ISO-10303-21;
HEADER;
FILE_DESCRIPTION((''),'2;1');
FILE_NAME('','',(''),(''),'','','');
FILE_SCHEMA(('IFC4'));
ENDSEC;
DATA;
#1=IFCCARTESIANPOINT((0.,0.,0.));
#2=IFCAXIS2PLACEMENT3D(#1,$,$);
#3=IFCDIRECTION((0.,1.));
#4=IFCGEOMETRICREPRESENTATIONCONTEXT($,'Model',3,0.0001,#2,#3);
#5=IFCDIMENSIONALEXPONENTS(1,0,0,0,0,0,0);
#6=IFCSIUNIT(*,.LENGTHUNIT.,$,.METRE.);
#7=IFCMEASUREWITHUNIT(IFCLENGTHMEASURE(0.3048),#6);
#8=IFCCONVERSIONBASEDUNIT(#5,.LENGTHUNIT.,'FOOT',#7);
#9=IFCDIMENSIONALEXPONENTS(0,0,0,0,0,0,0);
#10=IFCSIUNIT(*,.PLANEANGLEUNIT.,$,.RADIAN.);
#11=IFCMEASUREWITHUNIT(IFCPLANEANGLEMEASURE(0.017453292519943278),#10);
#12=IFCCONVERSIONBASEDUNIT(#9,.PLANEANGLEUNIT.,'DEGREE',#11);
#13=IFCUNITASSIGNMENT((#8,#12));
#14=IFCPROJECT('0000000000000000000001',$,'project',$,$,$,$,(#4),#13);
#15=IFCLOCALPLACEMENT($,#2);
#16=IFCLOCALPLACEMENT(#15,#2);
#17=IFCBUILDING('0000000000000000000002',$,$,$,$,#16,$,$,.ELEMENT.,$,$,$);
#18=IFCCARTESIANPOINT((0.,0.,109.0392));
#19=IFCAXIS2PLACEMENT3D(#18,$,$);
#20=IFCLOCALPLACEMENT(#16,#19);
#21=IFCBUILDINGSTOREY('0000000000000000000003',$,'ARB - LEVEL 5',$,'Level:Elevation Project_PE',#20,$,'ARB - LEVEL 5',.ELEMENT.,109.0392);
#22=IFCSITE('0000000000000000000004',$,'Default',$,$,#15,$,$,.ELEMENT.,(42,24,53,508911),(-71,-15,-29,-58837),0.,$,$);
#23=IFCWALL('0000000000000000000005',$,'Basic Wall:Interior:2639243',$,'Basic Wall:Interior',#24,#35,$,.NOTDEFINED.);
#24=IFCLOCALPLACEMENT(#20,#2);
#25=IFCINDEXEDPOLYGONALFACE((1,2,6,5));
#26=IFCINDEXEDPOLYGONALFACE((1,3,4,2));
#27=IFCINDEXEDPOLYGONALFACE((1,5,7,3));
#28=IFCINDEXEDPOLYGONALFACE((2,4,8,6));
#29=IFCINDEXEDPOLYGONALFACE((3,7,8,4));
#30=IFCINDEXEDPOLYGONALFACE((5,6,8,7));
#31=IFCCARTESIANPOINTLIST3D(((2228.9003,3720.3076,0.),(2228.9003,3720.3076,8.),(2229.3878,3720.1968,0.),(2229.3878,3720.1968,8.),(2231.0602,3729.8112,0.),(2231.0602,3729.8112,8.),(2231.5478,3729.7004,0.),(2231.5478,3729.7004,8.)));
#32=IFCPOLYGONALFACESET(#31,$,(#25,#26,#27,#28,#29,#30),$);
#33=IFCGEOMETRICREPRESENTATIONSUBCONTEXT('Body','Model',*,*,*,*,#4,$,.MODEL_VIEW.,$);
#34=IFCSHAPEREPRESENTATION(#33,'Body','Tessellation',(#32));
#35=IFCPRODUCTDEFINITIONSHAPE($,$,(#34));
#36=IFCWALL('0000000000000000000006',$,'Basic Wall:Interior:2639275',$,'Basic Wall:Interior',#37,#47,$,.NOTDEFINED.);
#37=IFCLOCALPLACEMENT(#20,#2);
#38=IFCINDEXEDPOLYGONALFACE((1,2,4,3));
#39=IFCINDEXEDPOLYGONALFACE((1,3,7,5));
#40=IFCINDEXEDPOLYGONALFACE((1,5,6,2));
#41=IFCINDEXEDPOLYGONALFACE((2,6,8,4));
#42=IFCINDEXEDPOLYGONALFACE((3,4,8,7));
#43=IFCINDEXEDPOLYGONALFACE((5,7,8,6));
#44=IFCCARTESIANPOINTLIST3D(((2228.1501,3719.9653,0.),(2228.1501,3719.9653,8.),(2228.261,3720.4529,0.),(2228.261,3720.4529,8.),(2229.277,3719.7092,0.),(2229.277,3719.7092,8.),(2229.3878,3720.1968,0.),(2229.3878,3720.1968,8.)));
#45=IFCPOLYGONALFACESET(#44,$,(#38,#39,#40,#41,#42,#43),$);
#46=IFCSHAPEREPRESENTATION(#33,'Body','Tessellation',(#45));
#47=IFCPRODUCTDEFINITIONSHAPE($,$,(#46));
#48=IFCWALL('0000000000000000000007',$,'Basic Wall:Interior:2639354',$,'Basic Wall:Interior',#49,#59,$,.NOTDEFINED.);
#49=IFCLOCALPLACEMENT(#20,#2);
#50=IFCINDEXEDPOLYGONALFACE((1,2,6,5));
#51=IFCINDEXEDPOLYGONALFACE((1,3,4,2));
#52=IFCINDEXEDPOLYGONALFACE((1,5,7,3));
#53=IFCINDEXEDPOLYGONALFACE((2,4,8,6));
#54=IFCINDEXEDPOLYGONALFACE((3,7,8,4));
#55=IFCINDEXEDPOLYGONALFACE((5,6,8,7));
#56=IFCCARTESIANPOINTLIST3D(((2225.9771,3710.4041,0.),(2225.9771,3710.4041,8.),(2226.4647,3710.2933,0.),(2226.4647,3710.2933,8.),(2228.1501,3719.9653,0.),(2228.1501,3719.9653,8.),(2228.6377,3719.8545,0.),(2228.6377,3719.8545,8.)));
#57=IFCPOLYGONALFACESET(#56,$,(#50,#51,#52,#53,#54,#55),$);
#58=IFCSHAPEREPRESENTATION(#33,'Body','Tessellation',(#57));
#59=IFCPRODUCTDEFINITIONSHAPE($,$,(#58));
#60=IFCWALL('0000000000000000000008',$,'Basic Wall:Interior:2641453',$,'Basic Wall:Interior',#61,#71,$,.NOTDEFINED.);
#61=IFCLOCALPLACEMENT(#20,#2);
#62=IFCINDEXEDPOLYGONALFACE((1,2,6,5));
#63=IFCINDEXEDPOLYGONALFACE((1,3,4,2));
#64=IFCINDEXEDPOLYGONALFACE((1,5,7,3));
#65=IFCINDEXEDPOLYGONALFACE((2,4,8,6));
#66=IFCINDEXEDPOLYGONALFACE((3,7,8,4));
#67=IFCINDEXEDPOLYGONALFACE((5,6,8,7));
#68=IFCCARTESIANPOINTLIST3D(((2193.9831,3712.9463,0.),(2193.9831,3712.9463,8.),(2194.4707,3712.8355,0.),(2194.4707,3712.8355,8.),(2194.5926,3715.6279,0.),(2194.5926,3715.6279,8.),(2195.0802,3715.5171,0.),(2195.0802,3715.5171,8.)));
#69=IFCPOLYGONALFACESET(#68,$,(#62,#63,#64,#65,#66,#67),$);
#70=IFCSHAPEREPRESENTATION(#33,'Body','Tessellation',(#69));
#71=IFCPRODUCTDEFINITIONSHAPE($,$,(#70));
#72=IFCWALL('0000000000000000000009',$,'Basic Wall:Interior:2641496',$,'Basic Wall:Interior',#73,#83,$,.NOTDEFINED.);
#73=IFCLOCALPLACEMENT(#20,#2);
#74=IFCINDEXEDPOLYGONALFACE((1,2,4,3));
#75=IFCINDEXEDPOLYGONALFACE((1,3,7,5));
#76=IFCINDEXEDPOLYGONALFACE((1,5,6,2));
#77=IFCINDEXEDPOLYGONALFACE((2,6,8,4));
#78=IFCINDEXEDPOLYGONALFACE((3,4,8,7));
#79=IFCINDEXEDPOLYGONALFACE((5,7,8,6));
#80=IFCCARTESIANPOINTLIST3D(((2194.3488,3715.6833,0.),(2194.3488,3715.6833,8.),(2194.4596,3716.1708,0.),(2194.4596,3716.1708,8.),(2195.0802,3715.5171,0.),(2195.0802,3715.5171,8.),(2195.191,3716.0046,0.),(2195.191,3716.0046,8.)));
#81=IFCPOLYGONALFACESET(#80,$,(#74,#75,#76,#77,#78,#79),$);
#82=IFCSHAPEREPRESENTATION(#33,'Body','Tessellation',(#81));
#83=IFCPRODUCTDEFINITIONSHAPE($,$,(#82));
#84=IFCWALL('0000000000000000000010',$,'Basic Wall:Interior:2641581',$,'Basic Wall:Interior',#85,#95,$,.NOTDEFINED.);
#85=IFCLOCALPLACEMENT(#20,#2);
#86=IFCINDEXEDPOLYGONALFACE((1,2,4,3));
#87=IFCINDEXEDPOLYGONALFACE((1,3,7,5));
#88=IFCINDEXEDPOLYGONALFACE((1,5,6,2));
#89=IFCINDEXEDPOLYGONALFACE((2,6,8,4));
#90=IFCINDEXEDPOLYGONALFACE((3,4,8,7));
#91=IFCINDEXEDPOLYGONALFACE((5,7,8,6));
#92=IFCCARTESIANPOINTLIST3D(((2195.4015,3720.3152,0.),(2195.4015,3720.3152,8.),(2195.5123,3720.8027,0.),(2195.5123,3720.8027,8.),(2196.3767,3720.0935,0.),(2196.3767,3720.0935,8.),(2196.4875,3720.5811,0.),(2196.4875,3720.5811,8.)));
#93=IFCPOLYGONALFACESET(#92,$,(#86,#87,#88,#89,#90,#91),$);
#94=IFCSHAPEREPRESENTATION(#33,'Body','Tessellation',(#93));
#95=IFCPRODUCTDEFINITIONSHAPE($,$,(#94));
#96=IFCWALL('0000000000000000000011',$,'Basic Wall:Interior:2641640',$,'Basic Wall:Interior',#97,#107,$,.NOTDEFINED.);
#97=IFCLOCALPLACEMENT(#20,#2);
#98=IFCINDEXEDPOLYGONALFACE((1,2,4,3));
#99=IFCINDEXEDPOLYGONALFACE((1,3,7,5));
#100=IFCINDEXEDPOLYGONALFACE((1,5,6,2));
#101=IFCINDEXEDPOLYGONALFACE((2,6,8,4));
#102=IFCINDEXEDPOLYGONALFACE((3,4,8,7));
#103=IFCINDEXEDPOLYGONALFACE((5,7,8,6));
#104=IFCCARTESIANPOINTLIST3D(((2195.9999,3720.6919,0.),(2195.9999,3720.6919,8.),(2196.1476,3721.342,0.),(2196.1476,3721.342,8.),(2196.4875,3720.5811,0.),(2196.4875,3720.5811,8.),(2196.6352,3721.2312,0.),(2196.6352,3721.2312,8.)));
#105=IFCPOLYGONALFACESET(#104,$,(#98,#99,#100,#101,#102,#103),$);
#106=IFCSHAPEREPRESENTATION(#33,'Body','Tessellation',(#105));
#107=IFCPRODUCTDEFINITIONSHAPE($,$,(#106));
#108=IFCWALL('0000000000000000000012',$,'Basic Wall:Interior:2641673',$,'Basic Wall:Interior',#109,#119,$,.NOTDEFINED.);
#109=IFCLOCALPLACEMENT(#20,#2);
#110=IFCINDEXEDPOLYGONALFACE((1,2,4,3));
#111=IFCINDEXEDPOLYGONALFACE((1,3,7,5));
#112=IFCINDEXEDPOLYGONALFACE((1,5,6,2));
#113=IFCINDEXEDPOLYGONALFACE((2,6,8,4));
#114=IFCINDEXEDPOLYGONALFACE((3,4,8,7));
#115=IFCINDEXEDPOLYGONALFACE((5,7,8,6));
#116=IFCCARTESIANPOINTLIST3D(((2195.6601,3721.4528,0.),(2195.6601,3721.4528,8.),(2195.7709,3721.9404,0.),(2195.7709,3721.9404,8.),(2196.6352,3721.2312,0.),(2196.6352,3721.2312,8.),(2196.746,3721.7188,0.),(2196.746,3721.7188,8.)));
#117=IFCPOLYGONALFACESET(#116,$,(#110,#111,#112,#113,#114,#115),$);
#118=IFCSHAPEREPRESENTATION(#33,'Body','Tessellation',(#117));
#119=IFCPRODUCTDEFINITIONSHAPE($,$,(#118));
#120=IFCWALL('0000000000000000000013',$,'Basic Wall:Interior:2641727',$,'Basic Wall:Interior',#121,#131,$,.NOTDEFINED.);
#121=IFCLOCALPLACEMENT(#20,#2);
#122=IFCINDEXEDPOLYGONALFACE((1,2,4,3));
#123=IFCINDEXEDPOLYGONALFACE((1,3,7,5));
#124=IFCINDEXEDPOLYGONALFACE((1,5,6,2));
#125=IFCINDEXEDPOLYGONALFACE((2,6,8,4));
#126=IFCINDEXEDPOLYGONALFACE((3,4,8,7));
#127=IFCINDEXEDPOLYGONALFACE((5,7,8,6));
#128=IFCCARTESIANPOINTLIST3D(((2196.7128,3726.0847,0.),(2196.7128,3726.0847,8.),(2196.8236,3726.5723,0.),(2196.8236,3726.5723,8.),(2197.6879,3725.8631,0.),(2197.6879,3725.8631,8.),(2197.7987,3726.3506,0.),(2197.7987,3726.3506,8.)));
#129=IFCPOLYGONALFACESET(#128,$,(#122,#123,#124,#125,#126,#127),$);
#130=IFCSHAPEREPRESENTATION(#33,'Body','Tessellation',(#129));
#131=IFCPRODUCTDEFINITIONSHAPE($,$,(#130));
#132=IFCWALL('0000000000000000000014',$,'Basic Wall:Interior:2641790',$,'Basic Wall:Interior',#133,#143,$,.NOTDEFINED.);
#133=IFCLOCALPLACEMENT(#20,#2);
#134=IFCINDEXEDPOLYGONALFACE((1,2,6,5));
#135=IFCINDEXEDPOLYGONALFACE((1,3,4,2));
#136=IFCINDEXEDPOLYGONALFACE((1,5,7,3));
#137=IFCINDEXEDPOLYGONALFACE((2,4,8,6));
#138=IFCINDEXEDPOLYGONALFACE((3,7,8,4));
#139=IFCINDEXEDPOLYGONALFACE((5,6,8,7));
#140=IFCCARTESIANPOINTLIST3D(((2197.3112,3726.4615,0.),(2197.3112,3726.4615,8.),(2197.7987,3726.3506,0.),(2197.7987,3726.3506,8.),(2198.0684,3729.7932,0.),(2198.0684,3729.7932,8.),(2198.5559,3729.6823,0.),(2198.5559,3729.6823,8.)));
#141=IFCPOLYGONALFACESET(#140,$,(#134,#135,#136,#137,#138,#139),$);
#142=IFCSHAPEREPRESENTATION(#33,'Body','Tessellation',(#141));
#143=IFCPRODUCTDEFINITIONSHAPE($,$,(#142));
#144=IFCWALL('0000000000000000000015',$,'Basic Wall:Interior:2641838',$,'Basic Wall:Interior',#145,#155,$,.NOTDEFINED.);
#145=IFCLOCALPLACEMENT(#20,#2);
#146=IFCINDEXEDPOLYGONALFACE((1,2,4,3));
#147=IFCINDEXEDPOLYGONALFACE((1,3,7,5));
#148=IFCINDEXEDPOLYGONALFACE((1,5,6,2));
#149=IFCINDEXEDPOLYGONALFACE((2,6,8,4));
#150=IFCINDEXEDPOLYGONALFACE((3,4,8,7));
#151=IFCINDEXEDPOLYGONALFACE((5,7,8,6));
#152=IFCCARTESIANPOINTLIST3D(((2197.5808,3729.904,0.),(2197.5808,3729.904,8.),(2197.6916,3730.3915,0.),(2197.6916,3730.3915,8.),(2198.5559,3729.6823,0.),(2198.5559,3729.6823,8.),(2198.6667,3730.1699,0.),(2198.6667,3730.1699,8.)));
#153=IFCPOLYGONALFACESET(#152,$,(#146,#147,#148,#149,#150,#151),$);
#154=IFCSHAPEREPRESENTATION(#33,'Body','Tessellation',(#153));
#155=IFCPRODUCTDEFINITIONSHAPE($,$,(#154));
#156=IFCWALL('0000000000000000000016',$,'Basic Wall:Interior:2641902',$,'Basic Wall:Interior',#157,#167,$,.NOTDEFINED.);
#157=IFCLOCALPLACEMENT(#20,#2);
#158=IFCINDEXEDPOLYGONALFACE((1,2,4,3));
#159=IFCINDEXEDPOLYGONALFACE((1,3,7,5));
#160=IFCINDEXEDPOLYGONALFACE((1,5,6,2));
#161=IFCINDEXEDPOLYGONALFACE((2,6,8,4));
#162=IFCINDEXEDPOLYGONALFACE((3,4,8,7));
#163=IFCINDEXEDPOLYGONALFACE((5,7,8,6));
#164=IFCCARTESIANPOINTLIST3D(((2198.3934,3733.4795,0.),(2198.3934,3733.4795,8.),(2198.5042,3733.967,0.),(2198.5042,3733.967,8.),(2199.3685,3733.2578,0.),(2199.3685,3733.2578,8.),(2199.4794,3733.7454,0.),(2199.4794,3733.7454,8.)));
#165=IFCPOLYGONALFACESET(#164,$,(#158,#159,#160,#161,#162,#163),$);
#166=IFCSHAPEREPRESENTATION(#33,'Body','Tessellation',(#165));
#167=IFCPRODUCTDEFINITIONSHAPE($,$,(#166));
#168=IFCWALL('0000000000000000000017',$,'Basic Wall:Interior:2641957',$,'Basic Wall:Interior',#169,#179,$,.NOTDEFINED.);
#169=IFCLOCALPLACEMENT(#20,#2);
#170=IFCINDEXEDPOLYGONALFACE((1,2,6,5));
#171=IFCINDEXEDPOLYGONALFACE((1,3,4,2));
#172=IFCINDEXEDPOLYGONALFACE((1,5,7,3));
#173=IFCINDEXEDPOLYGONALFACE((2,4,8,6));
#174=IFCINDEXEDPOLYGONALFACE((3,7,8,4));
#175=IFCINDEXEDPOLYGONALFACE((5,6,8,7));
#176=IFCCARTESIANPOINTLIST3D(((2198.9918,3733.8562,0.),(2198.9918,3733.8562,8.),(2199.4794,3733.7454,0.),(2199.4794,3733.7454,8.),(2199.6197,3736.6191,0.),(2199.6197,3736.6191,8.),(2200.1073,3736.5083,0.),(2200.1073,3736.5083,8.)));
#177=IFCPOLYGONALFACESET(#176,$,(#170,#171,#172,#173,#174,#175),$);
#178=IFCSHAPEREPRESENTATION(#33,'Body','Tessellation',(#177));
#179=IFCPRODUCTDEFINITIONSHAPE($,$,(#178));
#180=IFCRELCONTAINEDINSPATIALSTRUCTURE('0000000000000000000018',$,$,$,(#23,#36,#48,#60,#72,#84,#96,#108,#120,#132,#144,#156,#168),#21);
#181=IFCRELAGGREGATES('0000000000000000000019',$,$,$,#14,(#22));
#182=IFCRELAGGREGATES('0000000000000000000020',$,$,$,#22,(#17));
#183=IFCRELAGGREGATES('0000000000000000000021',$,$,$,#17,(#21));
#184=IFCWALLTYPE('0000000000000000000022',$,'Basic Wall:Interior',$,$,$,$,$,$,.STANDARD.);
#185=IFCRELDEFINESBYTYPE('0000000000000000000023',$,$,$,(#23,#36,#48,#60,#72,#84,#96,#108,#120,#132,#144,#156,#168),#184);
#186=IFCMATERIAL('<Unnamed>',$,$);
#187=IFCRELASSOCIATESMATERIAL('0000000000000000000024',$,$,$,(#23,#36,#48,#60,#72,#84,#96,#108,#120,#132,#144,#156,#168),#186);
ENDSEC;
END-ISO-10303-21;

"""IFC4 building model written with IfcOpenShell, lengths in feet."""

from ifc_helpers import new_model, entity, si_unit, converted_unit, direction, frame, origin, place, context, subcontext, project, spatial, indexed_curve, outline, extrude, material, type_object, element, save


model = new_model("IFC4")

# Units and contexts
model_context = context("Model", 3, precision=0.0001, world=origin(), true_north=direction((0.0, 1.0)))
body_context = subcontext(model_context, "Body", "Model", "MODEL_VIEW")
ifc_project = project(units=[converted_unit("LENGTHUNIT", "FOOT", entity("IfcLengthMeasure", 0.3048), si_unit("LENGTHUNIT", "METRE"), dimensions=[1, 0, 0, 0, 0, 0, 0]), converted_unit("PLANEANGLEUNIT", "DEGREE", entity("IfcPlaneAngleMeasure", 0.017453292519943278), si_unit("PLANEANGLEUNIT", "RADIAN"), dimensions=[0, 0, 0, 0, 0, 0, 0])], contexts=[model_context])

# Site, building, storey
site_placement = place(None, origin())
site = spatial("IfcSite", under=ifc_project, at=site_placement, Name="Default", CompositionType="ELEMENT", RefLatitude=(42, 24, 53, 508911), RefLongitude=(-71, -15, -29, -58837), RefElevation=0.0)
building_placement = place(site_placement, origin())
building = spatial("IfcBuilding", under=site, at=building_placement, CompositionType="ELEMENT")
storey_placement = place(building_placement, frame((0.0, 0.0, 109.0392)))
storey = spatial("IfcBuildingStorey", under=building, at=storey_placement, Name="ARB - LEVEL 5", ObjectType="Level:Elevation Project_PE", LongName="ARB - LEVEL 5", CompositionType="ELEMENT", Elevation=109.0392)

# Walls
ifc_material_1 = material(Name="<Unnamed>")
wall_type = type_object("IfcWallType", Name="Basic Wall:Interior", PredefinedType="STANDARD")
wall_1_placement = place(storey_placement, frame((2231.304, 3729.7558, 0.0), z_axis=(0.0, 0.0, 1.0), x_axis=(-0.221622, -0.975133, 0.0)))
element("IfcWall", 1, at=wall_1_placement, inside=storey, type_object=wall_type, material=ifc_material_1, Name="Basic Wall:Interior:2639243", ObjectType="Basic Wall:Interior", PredefinedType="NOTDEFINED", context=body_context, shape_type="SweptSolid", body=[
    extrude(outline(indexed_curve([(9.746, 0.25), (0.0, 0.25), (0.0, -0.25), (9.746, -0.25), (9.746, 0.25)], self_intersect=False)), origin(), (0.0, 0.0, 1.0), 8.0),
])
wall_2_placement = place(storey_placement, frame((2229.3324, 3719.953, 0.0), z_axis=(0.0, 0.0, 1.0), x_axis=(-0.975133, 0.221622, 0.0)))
element("IfcWall", 2, at=wall_2_placement, inside=storey, type_object=wall_type, material=ifc_material_1, Name="Basic Wall:Interior:2639275", ObjectType="Basic Wall:Interior", PredefinedType="NOTDEFINED", context=body_context, shape_type="SweptSolid", body=[
    extrude(outline(indexed_curve([(1.1556, 0.25), (0.0, 0.25), (0.0, -0.25), (1.1556, -0.25), (1.1556, 0.25)], self_intersect=False)), origin(), (0.0, 0.0, 1.0), 8.0),
])
wall_3_placement = place(storey_placement, frame((2228.3939, 3719.9099, 0.0), z_axis=(0.0, 0.0, 1.0), x_axis=(-0.221622, -0.975133, 0.0)))
element("IfcWall", 3, at=wall_3_placement, inside=storey, type_object=wall_type, material=ifc_material_1, Name="Basic Wall:Interior:2639354", ObjectType="Basic Wall:Interior", PredefinedType="NOTDEFINED", context=body_context, shape_type="SweptSolid", body=[
    extrude(outline(indexed_curve([(9.805, 0.25), (0.0, 0.25), (0.0, -0.25), (9.805, -0.25), (9.805, 0.25)], self_intersect=False)), origin(), (0.0, 0.0, 1.0), 8.0),
])
wall_4_placement = place(storey_placement, frame((2194.2269, 3712.8909, 0.0), z_axis=(0.0, 0.0, 1.0), x_axis=(0.221622, 0.975133, 0.0)))
element("IfcWall", 4, at=wall_4_placement, inside=storey, type_object=wall_type, material=ifc_material_1, Name="Basic Wall:Interior:2641453", ObjectType="Basic Wall:Interior", PredefinedType="NOTDEFINED", context=body_context, shape_type="SweptSolid", body=[
    extrude(outline(indexed_curve([(2.75, 0.25), (0.0, 0.25), (0.0, -0.25), (2.75, -0.25), (2.75, 0.25)], self_intersect=False)), origin(), (0.0, 0.0, 1.0), 8.0),
])
wall_5_placement = place(storey_placement, frame((2195.1356, 3715.7608, 0.0), z_axis=(0.0, 0.0, 1.0), x_axis=(-0.975133, 0.221622, 0.0)))
element("IfcWall", 5, at=wall_5_placement, inside=storey, type_object=wall_type, material=ifc_material_1, Name="Basic Wall:Interior:2641496", ObjectType="Basic Wall:Interior", PredefinedType="NOTDEFINED", context=body_context, shape_type="SweptSolid", body=[
    extrude(outline(indexed_curve([(0.75, 0.25), (0.0, 0.25), (0.0, -0.25), (0.75, -0.25), (0.75, 0.25)], self_intersect=False)), origin(), (0.0, 0.0, 1.0), 8.0),
])
wall_6_placement = place(storey_placement, frame((2195.4569, 3720.5589, 0.0), z_axis=(0.0, 0.0, 1.0), x_axis=(0.975133, -0.221622, 0.0)))
element("IfcWall", 6, at=wall_6_placement, inside=storey, type_object=wall_type, material=ifc_material_1, Name="Basic Wall:Interior:2641581", ObjectType="Basic Wall:Interior", PredefinedType="NOTDEFINED", context=body_context, shape_type="SweptSolid", body=[
    extrude(outline(indexed_curve([(1.0, 0.25), (0.0, 0.25), (0.0, -0.25), (1.0, -0.25), (1.0, 0.25)], self_intersect=False)), origin(), (0.0, 0.0, 1.0), 8.0),
])
wall_7_placement = place(storey_placement, frame((2196.2437, 3720.6365, 0.0), z_axis=(0.0, 0.0, 1.0), x_axis=(0.221622, 0.975133, 0.0)))
element("IfcWall", 7, at=wall_7_placement, inside=storey, type_object=wall_type, material=ifc_material_1, Name="Basic Wall:Interior:2641640", ObjectType="Basic Wall:Interior", PredefinedType="NOTDEFINED", context=body_context, shape_type="SweptSolid", body=[
    extrude(outline(indexed_curve([(0.6667, 0.25), (0.0, 0.25), (0.0, -0.25), (0.6667, -0.25), (0.6667, 0.25)], self_intersect=False)), origin(), (0.0, 0.0, 1.0), 8.0),
])
wall_8_placement = place(storey_placement, frame((2196.6906, 3721.475, 0.0), z_axis=(0.0, 0.0, 1.0), x_axis=(-0.975133, 0.221622, 0.0)))
element("IfcWall", 8, at=wall_8_placement, inside=storey, type_object=wall_type, material=ifc_material_1, Name="Basic Wall:Interior:2641673", ObjectType="Basic Wall:Interior", PredefinedType="NOTDEFINED", context=body_context, shape_type="SweptSolid", body=[
    extrude(outline(indexed_curve([(1.0, 0.25), (0.0, 0.25), (0.0, -0.25), (1.0, -0.25), (1.0, 0.25)], self_intersect=False)), origin(), (0.0, 0.0, 1.0), 8.0),
])
wall_9_placement = place(storey_placement, frame((2196.7682, 3726.3285, 0.0), z_axis=(0.0, 0.0, 1.0), x_axis=(0.975133, -0.221622, 0.0)))
element("IfcWall", 9, at=wall_9_placement, inside=storey, type_object=wall_type, material=ifc_material_1, Name="Basic Wall:Interior:2641727", ObjectType="Basic Wall:Interior", PredefinedType="NOTDEFINED", context=body_context, shape_type="SweptSolid", body=[
    extrude(outline(indexed_curve([(1.0, 0.25), (0.0, 0.25), (0.0, -0.25), (1.0, -0.25), (1.0, 0.25)], self_intersect=False)), origin(), (0.0, 0.0, 1.0), 8.0),
])
wall_10_placement = place(storey_placement, frame((2197.5549, 3726.406, 0.0), z_axis=(0.0, 0.0, 1.0), x_axis=(0.221622, 0.975133, 0.0)))
element("IfcWall", 10, at=wall_10_placement, inside=storey, type_object=wall_type, material=ifc_material_1, Name="Basic Wall:Interior:2641790", ObjectType="Basic Wall:Interior", PredefinedType="NOTDEFINED", context=body_context, shape_type="SweptSolid", body=[
    extrude(outline(indexed_curve([(3.4167, 0.25), (0.0, 0.25), (0.0, -0.25), (3.4167, -0.25), (3.4167, 0.25)], self_intersect=False)), origin(), (0.0, 0.0, 1.0), 8.0),
])
wall_11_placement = place(storey_placement, frame((2198.6113, 3729.9261, 0.0), z_axis=(0.0, 0.0, 1.0), x_axis=(-0.975133, 0.221622, 0.0)))
element("IfcWall", 11, at=wall_11_placement, inside=storey, type_object=wall_type, material=ifc_material_1, Name="Basic Wall:Interior:2641838", ObjectType="Basic Wall:Interior", PredefinedType="NOTDEFINED", context=body_context, shape_type="SweptSolid", body=[
    extrude(outline(indexed_curve([(1.0, 0.25), (0.0, 0.25), (0.0, -0.25), (1.0, -0.25), (1.0, 0.25)], self_intersect=False)), origin(), (0.0, 0.0, 1.0), 8.0),
])
wall_12_placement = place(storey_placement, frame((2198.4488, 3733.7232, 0.0), z_axis=(0.0, 0.0, 1.0), x_axis=(0.975133, -0.221622, 0.0)))
element("IfcWall", 12, at=wall_12_placement, inside=storey, type_object=wall_type, material=ifc_material_1, Name="Basic Wall:Interior:2641902", ObjectType="Basic Wall:Interior", PredefinedType="NOTDEFINED", context=body_context, shape_type="SweptSolid", body=[
    extrude(outline(indexed_curve([(1.0, 0.25), (0.0, 0.25), (0.0, -0.25), (1.0, -0.25), (1.0, 0.25)], self_intersect=False)), origin(), (0.0, 0.0, 1.0), 8.0),
])
wall_13_placement = place(storey_placement, frame((2199.2356, 3733.8008, 0.0), z_axis=(0.0, 0.0, 1.0), x_axis=(0.221622, 0.975133, 0.0)))
element("IfcWall", 13, at=wall_13_placement, inside=storey, type_object=wall_type, material=ifc_material_1, Name="Basic Wall:Interior:2641957", ObjectType="Basic Wall:Interior", PredefinedType="NOTDEFINED", context=body_context, shape_type="SweptSolid", body=[
    extrude(outline(indexed_curve([(2.8333, 0.25), (0.0, 0.25), (0.0, -0.25), (2.8333, -0.25), (2.8333, 0.25)], self_intersect=False)), origin(), (0.0, 0.0, 1.0), 8.0),
])

save(model, "model.ifc")
